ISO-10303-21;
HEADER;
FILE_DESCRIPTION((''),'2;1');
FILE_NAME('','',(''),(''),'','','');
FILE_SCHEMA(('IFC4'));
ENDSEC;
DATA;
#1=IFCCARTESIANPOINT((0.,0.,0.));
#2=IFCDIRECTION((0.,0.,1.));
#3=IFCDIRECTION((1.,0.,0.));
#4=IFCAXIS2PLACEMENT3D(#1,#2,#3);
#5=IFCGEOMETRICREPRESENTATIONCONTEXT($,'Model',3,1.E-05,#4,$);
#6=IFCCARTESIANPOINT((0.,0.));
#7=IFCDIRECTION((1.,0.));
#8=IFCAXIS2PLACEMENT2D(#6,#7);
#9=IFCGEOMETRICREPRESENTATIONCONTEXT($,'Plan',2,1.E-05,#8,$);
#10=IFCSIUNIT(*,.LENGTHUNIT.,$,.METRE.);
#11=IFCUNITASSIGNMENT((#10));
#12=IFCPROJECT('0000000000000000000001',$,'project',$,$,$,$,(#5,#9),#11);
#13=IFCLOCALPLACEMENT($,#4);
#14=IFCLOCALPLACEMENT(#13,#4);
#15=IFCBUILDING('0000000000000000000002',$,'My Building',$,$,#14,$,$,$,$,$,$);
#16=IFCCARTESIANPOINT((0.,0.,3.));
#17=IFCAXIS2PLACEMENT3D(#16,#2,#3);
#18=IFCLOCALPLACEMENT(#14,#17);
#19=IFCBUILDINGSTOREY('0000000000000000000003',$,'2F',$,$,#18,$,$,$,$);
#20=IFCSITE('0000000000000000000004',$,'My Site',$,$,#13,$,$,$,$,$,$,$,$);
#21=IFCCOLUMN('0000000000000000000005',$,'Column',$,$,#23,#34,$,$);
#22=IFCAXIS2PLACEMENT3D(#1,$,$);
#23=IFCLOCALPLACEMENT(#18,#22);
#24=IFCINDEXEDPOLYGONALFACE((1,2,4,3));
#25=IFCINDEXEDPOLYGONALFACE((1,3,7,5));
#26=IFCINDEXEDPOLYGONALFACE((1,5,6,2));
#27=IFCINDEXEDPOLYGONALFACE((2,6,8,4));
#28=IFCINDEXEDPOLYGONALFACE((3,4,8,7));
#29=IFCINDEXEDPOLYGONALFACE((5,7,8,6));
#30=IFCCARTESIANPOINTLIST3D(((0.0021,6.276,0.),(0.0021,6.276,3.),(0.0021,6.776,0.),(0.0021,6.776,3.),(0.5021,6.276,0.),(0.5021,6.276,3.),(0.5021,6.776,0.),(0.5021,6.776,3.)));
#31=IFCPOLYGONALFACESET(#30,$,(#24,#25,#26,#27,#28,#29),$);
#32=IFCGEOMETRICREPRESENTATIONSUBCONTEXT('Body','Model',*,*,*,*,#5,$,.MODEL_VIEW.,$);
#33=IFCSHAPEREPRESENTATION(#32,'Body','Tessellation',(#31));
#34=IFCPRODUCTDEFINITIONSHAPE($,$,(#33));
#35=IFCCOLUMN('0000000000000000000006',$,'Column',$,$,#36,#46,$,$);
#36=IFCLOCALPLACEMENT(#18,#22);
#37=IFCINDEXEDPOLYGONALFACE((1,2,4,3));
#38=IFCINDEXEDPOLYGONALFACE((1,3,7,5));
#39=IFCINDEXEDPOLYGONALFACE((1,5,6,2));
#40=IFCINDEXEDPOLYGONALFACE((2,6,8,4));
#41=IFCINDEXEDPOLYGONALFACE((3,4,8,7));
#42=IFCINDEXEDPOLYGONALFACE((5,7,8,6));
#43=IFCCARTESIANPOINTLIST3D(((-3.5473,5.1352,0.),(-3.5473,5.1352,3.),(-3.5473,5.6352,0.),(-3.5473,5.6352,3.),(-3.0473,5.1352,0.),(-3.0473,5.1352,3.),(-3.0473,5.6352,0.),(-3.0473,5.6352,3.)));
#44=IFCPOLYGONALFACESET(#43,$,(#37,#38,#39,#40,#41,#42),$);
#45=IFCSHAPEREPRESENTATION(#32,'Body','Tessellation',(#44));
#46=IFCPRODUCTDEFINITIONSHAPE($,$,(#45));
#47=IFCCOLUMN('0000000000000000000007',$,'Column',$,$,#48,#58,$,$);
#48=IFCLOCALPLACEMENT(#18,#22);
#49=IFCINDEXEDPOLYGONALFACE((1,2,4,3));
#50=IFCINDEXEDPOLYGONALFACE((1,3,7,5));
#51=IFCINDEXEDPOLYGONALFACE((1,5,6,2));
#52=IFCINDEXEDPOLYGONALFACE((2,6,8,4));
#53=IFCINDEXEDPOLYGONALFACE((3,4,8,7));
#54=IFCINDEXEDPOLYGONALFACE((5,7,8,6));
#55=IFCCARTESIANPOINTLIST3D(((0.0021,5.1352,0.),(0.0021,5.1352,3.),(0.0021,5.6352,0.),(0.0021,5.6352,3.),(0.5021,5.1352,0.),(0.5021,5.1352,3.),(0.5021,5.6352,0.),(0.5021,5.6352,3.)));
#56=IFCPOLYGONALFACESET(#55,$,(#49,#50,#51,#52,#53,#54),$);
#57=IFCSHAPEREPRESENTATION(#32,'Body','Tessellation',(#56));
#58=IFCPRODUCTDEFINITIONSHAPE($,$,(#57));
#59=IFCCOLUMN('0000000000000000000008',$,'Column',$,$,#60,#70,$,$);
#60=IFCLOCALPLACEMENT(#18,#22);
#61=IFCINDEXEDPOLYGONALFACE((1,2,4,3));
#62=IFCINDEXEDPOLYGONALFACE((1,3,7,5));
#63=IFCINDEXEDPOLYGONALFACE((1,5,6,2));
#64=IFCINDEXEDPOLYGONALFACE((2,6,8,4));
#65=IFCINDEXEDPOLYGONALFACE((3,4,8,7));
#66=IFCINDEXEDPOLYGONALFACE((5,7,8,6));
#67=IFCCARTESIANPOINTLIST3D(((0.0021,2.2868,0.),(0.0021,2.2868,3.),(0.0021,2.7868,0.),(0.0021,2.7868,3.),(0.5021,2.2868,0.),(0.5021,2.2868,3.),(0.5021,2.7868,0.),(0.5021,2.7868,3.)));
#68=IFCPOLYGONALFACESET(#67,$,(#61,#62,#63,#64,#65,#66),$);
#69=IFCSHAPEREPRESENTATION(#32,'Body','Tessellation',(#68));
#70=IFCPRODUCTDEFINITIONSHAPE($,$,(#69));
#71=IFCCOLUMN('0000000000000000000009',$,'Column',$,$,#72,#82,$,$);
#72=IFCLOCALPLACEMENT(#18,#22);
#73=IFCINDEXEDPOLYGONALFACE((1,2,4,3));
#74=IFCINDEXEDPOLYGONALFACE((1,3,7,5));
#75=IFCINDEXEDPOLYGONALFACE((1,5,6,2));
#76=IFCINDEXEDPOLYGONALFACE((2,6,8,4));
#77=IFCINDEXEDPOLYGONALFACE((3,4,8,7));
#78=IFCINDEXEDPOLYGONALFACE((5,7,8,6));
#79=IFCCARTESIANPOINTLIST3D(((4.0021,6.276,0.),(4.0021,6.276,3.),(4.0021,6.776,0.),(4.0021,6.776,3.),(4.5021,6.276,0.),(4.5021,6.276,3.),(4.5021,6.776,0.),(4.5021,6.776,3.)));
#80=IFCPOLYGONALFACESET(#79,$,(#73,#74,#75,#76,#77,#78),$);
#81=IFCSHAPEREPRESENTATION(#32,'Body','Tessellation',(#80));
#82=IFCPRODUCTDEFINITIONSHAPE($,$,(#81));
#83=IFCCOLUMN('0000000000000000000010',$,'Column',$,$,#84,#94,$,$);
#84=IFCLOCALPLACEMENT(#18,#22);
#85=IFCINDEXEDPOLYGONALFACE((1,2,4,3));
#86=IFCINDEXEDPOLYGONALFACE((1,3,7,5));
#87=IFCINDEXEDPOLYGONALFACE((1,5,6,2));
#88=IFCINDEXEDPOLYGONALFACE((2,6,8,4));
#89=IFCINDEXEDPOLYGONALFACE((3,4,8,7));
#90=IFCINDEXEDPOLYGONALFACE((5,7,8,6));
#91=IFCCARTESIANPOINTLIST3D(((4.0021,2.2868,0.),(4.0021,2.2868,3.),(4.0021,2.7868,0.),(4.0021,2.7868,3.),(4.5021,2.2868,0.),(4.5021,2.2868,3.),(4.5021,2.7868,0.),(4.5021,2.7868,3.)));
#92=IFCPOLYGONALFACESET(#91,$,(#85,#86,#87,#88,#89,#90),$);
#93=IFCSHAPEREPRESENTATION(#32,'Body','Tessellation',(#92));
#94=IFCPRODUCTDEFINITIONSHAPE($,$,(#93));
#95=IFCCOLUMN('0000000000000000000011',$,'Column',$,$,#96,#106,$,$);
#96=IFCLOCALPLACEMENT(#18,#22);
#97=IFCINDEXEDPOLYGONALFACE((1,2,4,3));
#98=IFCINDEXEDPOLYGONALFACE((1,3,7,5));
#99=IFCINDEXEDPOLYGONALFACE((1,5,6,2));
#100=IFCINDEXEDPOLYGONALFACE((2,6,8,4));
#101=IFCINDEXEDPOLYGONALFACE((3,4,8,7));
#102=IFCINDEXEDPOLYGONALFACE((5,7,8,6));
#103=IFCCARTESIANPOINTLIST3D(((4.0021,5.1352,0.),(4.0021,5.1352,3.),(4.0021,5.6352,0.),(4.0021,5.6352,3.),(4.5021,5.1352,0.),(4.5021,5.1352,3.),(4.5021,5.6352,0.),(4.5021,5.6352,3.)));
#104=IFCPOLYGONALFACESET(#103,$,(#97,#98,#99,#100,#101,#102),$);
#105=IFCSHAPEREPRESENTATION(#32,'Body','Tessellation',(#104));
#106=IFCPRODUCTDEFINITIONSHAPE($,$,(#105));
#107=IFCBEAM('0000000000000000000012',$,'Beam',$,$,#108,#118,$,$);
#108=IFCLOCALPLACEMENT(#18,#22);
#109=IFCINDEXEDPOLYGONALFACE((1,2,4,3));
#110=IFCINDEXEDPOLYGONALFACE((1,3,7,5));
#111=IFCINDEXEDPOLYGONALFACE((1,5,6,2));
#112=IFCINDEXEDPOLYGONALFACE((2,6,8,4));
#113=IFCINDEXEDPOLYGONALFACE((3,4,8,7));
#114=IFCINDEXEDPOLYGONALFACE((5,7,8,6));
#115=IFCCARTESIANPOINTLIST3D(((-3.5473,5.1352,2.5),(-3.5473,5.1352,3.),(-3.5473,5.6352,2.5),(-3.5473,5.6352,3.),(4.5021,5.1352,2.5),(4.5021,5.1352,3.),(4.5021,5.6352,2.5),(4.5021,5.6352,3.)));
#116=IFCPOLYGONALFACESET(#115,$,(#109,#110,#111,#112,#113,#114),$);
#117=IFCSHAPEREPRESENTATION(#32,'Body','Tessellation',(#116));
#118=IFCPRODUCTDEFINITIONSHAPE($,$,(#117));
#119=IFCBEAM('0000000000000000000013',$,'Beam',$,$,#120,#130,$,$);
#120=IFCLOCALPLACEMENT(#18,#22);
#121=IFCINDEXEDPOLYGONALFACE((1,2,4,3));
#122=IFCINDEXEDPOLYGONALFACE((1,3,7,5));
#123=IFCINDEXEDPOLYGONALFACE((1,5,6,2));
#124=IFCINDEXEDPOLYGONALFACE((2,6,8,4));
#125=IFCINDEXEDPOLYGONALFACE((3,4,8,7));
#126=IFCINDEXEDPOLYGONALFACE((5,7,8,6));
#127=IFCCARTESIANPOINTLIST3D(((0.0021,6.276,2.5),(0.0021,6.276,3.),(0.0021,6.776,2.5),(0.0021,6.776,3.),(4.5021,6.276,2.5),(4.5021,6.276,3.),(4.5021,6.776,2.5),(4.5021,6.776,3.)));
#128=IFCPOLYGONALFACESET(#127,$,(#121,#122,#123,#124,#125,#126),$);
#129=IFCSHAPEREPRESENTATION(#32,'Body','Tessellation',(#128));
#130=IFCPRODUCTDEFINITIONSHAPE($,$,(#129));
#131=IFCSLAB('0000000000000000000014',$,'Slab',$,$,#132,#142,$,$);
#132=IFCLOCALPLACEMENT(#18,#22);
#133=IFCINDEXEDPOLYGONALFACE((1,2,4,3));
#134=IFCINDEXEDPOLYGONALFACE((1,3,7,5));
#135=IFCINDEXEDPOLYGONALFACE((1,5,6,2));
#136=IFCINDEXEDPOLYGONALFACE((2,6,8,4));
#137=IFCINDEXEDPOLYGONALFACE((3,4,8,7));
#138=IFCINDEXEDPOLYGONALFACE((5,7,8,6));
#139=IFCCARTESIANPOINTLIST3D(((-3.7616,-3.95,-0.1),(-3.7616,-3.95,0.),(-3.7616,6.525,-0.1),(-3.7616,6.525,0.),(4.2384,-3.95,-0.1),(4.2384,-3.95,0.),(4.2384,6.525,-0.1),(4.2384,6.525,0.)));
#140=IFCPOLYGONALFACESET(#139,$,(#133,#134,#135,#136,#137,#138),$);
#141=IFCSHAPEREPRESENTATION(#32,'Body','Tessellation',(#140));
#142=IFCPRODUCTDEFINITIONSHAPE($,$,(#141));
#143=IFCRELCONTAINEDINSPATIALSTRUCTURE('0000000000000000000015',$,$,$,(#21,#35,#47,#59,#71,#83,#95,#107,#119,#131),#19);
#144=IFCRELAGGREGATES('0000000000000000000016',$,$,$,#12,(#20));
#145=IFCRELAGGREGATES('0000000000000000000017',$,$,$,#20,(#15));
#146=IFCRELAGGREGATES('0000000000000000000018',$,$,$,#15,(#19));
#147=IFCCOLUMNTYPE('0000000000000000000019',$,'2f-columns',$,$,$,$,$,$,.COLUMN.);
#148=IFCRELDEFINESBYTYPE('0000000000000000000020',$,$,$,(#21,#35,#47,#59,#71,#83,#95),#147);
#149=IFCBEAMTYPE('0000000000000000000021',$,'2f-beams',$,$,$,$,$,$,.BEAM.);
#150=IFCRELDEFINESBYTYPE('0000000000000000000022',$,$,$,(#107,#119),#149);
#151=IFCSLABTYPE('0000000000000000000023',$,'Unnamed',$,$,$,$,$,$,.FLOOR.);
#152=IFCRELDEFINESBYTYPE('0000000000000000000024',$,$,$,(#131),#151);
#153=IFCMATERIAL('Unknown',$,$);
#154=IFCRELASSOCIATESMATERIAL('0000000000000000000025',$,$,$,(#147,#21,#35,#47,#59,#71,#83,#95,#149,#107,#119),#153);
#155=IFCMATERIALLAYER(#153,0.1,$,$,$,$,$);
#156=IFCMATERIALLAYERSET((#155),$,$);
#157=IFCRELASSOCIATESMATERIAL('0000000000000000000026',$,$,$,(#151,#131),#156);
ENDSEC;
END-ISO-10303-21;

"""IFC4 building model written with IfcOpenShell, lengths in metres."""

from ifc_helpers import new_model, si_unit, frame, origin_with_axes, origin_2d_with_axis, place, context, subcontext, project, spatial, indexed_curve, rectangle, outline, extrude, material, layer, layer_set, layer_usage, material_profile, profile_set, profile_usage, type_object, element, save


model = new_model("IFC4")

# Units and contexts
model_context = context("Model", 3, precision=1e-05, world=origin_with_axes())
plan_context = context("Plan", 2, precision=1e-05, world=origin_2d_with_axis())
body_context_1 = subcontext(model_context, "Body", "Model", "MODEL_VIEW")
ifc_project = project(units=[si_unit("LENGTHUNIT", "METRE")], contexts=[model_context, plan_context])

# Site, building, storey
site_placement = place(None, origin_with_axes())
site = spatial("IfcSite", under=ifc_project, at=site_placement, Name="My Site")
building_placement = place(site_placement, origin_with_axes())
building = spatial("IfcBuilding", under=site, at=building_placement, Name="My Building")
storey_placement = place(building_placement, frame((0.0, 0.0, 3.0), z_axis=(0.0, 0.0, 1.0), x_axis=(1.0, 0.0, 0.0)))
storey = spatial("IfcBuildingStorey", under=building, at=storey_placement, Name="2F")

# Columns
ifc_material = material(Name="Unknown")
ifc_material_profile_1 = material_profile(ifc_material, rectangle(XDim=0.5, YDim=0.5))
ifc_profile_set_1 = profile_set([ifc_material_profile_1])
ifc_profile_usage_1 = profile_usage(ifc_profile_set_1, cardinal=7)
column_type = type_object("IfcColumnType", Name="2f-columns", PredefinedType="COLUMN", material=ifc_profile_set_1)
column_1_placement = place(storey_placement, frame((0.5021, 6.776, 0.0), z_axis=(0.0, 0.0, 1.0), x_axis=(1.0, 0.0, 0.0)))
element("IfcColumn", 1, at=column_1_placement, inside=storey, type_object=column_type, material=ifc_profile_usage_1, Name="Column", context=body_context_1, shape_type="SweptSolid", body=[
    extrude(rectangle(XDim=0.5, YDim=0.5), frame((-0.25, -0.25, 0.0), z_axis=(0.0, 0.0, 1.0), x_axis=(1.0, 0.0, 0.0)), (0.0, 0.0, 1.0), 3.0),
])
ifc_profile_usage_2 = profile_usage(ifc_profile_set_1, cardinal=5)
column_2_placement = place(storey_placement, frame((-3.2973, 5.3852, 0.0), z_axis=(0.0, 0.0, 1.0), x_axis=(1.0, 0.0, 0.0)))
element("IfcColumn", 2, at=column_2_placement, inside=storey, type_object=column_type, material=ifc_profile_usage_2, Name="Column", context=body_context_1, shape_type="SweptSolid", body=[
    extrude(rectangle(XDim=0.5, YDim=0.5), origin_with_axes(), (0.0, 0.0, 1.0), 3.0),
])
ifc_profile_usage_3 = profile_usage(ifc_profile_set_1, cardinal=5)
column_3_placement = place(storey_placement, frame((0.2521, 5.3852, 0.0), z_axis=(0.0, 0.0, 1.0), x_axis=(1.0, 0.0, 0.0)))
element("IfcColumn", 3, at=column_3_placement, inside=storey, type_object=column_type, material=ifc_profile_usage_3, Name="Column", context=body_context_1, shape_type="SweptSolid", body=[
    extrude(rectangle(XDim=0.5, YDim=0.5), origin_with_axes(), (0.0, 0.0, 1.0), 3.0),
])
ifc_profile_usage_4 = profile_usage(ifc_profile_set_1, cardinal=5)
column_4_placement = place(storey_placement, frame((0.2521, 2.5368, 0.0), z_axis=(0.0, 0.0, 1.0), x_axis=(1.0, 0.0, 0.0)))
element("IfcColumn", 4, at=column_4_placement, inside=storey, type_object=column_type, material=ifc_profile_usage_4, Name="Column", context=body_context_1, shape_type="SweptSolid", body=[
    extrude(rectangle(XDim=0.5, YDim=0.5), origin_with_axes(), (0.0, 0.0, 1.0), 3.0),
])
ifc_profile_usage_5 = profile_usage(ifc_profile_set_1, cardinal=7)
column_5_placement = place(storey_placement, frame((4.5021, 6.776, 0.0), z_axis=(0.0, 0.0, 1.0), x_axis=(1.0, 0.0, 0.0)))
element("IfcColumn", 5, at=column_5_placement, inside=storey, type_object=column_type, material=ifc_profile_usage_5, Name="Column", context=body_context_1, shape_type="SweptSolid", body=[
    extrude(rectangle(XDim=0.5, YDim=0.5), frame((-0.25, -0.25, 0.0), z_axis=(0.0, 0.0, 1.0), x_axis=(1.0, 0.0, 0.0)), (0.0, 0.0, 1.0), 3.0),
])
ifc_profile_usage_6 = profile_usage(ifc_profile_set_1, cardinal=5)
column_6_placement = place(storey_placement, frame((4.2521, 2.5368, 0.0), z_axis=(0.0, 0.0, 1.0), x_axis=(1.0, 0.0, 0.0)))
element("IfcColumn", 6, at=column_6_placement, inside=storey, type_object=column_type, material=ifc_profile_usage_6, Name="Column", context=body_context_1, shape_type="SweptSolid", body=[
    extrude(rectangle(XDim=0.5, YDim=0.5), origin_with_axes(), (0.0, 0.0, 1.0), 3.0),
])
ifc_profile_usage_7 = profile_usage(ifc_profile_set_1, cardinal=5)
column_7_placement = place(storey_placement, frame((4.2521, 5.3852, 0.0), z_axis=(0.0, 0.0, 1.0), x_axis=(1.0, 0.0, 0.0)))
element("IfcColumn", 7, at=column_7_placement, inside=storey, type_object=column_type, material=ifc_profile_usage_7, Name="Column", context=body_context_1, shape_type="SweptSolid", body=[
    extrude(rectangle(XDim=0.5, YDim=0.5), origin_with_axes(), (0.0, 0.0, 1.0), 3.0),
])

# Beams
ifc_material_profile_2 = material_profile(ifc_material, rectangle(XDim=0.5, YDim=0.5))
ifc_profile_set_2 = profile_set([ifc_material_profile_2])
ifc_profile_usage_8 = profile_usage(ifc_profile_set_2, cardinal=7)
beam_type = type_object("IfcBeamType", Name="2f-beams", PredefinedType="BEAM", material=ifc_profile_set_2)
beam_1_placement = place(storey_placement, frame((4.5021, 5.1352, 3.0), z_axis=(-1.0, 0.0, 0.0), x_axis=(0.0, -1.0, 0.0)))
element("IfcBeam", 8, at=beam_1_placement, inside=storey, type_object=beam_type, material=ifc_profile_usage_8, Name="Beam", context=body_context_1, shape_type="SweptSolid", body=[
    extrude(rectangle(XDim=0.5, YDim=0.5), frame((-0.25, -0.25, 0.0), z_axis=(0.0, 0.0, 1.0), x_axis=(1.0, 0.0, 0.0)), (0.0, 0.0, 1.0), 8.0493),
])
ifc_profile_usage_9 = profile_usage(ifc_profile_set_2, cardinal=1)
beam_2_placement = place(storey_placement, frame((0.0021, 6.776, 2.5), z_axis=(1.0, 0.0, 0.0), x_axis=(0.0, 1.0, 0.0)))
element("IfcBeam", 9, at=beam_2_placement, inside=storey, type_object=beam_type, material=ifc_profile_usage_9, Name="Beam", context=body_context_1, shape_type="SweptSolid", body=[
    extrude(rectangle(XDim=0.5, YDim=0.5), frame((-0.25, 0.25, 0.0), z_axis=(0.0, 0.0, 1.0), x_axis=(1.0, 0.0, 0.0)), (0.0, 0.0, 1.0), 4.5),
])

# Slab
ifc_layer_1 = layer(ifc_material, 0.1)
ifc_layer_set_1 = layer_set([ifc_layer_1])
ifc_layer_usage_1 = layer_usage(ifc_layer_set_1, "AXIS3", "POSITIVE", -0.1)
slab_type = type_object("IfcSlabType", Name="Unnamed", PredefinedType="FLOOR", material=ifc_layer_set_1)
slab_placement = place(storey_placement, frame((4.2384, 6.525, 0.0), z_axis=(0.0, 0.0, 1.0), x_axis=(1.0, 0.0, 0.0)))
element("IfcSlab", 10, at=slab_placement, inside=storey, type_object=slab_type, material=ifc_layer_usage_1, Name="Slab", context=body_context_1, shape_type="SweptSolid", body=[
    extrude(outline(indexed_curve([(0.0, 0.0), (-8.0, 0.0), (-8.0, -10.475), (0.0, -10.475), (0.0, 0.0)])), frame((0.0, 0.0, -0.1), z_axis=(0.0, 0.0, 1.0), x_axis=(1.0, 0.0, 0.0)), (0.0, 0.0, 1.0), 0.1),
])

save(model, "model.ifc")
